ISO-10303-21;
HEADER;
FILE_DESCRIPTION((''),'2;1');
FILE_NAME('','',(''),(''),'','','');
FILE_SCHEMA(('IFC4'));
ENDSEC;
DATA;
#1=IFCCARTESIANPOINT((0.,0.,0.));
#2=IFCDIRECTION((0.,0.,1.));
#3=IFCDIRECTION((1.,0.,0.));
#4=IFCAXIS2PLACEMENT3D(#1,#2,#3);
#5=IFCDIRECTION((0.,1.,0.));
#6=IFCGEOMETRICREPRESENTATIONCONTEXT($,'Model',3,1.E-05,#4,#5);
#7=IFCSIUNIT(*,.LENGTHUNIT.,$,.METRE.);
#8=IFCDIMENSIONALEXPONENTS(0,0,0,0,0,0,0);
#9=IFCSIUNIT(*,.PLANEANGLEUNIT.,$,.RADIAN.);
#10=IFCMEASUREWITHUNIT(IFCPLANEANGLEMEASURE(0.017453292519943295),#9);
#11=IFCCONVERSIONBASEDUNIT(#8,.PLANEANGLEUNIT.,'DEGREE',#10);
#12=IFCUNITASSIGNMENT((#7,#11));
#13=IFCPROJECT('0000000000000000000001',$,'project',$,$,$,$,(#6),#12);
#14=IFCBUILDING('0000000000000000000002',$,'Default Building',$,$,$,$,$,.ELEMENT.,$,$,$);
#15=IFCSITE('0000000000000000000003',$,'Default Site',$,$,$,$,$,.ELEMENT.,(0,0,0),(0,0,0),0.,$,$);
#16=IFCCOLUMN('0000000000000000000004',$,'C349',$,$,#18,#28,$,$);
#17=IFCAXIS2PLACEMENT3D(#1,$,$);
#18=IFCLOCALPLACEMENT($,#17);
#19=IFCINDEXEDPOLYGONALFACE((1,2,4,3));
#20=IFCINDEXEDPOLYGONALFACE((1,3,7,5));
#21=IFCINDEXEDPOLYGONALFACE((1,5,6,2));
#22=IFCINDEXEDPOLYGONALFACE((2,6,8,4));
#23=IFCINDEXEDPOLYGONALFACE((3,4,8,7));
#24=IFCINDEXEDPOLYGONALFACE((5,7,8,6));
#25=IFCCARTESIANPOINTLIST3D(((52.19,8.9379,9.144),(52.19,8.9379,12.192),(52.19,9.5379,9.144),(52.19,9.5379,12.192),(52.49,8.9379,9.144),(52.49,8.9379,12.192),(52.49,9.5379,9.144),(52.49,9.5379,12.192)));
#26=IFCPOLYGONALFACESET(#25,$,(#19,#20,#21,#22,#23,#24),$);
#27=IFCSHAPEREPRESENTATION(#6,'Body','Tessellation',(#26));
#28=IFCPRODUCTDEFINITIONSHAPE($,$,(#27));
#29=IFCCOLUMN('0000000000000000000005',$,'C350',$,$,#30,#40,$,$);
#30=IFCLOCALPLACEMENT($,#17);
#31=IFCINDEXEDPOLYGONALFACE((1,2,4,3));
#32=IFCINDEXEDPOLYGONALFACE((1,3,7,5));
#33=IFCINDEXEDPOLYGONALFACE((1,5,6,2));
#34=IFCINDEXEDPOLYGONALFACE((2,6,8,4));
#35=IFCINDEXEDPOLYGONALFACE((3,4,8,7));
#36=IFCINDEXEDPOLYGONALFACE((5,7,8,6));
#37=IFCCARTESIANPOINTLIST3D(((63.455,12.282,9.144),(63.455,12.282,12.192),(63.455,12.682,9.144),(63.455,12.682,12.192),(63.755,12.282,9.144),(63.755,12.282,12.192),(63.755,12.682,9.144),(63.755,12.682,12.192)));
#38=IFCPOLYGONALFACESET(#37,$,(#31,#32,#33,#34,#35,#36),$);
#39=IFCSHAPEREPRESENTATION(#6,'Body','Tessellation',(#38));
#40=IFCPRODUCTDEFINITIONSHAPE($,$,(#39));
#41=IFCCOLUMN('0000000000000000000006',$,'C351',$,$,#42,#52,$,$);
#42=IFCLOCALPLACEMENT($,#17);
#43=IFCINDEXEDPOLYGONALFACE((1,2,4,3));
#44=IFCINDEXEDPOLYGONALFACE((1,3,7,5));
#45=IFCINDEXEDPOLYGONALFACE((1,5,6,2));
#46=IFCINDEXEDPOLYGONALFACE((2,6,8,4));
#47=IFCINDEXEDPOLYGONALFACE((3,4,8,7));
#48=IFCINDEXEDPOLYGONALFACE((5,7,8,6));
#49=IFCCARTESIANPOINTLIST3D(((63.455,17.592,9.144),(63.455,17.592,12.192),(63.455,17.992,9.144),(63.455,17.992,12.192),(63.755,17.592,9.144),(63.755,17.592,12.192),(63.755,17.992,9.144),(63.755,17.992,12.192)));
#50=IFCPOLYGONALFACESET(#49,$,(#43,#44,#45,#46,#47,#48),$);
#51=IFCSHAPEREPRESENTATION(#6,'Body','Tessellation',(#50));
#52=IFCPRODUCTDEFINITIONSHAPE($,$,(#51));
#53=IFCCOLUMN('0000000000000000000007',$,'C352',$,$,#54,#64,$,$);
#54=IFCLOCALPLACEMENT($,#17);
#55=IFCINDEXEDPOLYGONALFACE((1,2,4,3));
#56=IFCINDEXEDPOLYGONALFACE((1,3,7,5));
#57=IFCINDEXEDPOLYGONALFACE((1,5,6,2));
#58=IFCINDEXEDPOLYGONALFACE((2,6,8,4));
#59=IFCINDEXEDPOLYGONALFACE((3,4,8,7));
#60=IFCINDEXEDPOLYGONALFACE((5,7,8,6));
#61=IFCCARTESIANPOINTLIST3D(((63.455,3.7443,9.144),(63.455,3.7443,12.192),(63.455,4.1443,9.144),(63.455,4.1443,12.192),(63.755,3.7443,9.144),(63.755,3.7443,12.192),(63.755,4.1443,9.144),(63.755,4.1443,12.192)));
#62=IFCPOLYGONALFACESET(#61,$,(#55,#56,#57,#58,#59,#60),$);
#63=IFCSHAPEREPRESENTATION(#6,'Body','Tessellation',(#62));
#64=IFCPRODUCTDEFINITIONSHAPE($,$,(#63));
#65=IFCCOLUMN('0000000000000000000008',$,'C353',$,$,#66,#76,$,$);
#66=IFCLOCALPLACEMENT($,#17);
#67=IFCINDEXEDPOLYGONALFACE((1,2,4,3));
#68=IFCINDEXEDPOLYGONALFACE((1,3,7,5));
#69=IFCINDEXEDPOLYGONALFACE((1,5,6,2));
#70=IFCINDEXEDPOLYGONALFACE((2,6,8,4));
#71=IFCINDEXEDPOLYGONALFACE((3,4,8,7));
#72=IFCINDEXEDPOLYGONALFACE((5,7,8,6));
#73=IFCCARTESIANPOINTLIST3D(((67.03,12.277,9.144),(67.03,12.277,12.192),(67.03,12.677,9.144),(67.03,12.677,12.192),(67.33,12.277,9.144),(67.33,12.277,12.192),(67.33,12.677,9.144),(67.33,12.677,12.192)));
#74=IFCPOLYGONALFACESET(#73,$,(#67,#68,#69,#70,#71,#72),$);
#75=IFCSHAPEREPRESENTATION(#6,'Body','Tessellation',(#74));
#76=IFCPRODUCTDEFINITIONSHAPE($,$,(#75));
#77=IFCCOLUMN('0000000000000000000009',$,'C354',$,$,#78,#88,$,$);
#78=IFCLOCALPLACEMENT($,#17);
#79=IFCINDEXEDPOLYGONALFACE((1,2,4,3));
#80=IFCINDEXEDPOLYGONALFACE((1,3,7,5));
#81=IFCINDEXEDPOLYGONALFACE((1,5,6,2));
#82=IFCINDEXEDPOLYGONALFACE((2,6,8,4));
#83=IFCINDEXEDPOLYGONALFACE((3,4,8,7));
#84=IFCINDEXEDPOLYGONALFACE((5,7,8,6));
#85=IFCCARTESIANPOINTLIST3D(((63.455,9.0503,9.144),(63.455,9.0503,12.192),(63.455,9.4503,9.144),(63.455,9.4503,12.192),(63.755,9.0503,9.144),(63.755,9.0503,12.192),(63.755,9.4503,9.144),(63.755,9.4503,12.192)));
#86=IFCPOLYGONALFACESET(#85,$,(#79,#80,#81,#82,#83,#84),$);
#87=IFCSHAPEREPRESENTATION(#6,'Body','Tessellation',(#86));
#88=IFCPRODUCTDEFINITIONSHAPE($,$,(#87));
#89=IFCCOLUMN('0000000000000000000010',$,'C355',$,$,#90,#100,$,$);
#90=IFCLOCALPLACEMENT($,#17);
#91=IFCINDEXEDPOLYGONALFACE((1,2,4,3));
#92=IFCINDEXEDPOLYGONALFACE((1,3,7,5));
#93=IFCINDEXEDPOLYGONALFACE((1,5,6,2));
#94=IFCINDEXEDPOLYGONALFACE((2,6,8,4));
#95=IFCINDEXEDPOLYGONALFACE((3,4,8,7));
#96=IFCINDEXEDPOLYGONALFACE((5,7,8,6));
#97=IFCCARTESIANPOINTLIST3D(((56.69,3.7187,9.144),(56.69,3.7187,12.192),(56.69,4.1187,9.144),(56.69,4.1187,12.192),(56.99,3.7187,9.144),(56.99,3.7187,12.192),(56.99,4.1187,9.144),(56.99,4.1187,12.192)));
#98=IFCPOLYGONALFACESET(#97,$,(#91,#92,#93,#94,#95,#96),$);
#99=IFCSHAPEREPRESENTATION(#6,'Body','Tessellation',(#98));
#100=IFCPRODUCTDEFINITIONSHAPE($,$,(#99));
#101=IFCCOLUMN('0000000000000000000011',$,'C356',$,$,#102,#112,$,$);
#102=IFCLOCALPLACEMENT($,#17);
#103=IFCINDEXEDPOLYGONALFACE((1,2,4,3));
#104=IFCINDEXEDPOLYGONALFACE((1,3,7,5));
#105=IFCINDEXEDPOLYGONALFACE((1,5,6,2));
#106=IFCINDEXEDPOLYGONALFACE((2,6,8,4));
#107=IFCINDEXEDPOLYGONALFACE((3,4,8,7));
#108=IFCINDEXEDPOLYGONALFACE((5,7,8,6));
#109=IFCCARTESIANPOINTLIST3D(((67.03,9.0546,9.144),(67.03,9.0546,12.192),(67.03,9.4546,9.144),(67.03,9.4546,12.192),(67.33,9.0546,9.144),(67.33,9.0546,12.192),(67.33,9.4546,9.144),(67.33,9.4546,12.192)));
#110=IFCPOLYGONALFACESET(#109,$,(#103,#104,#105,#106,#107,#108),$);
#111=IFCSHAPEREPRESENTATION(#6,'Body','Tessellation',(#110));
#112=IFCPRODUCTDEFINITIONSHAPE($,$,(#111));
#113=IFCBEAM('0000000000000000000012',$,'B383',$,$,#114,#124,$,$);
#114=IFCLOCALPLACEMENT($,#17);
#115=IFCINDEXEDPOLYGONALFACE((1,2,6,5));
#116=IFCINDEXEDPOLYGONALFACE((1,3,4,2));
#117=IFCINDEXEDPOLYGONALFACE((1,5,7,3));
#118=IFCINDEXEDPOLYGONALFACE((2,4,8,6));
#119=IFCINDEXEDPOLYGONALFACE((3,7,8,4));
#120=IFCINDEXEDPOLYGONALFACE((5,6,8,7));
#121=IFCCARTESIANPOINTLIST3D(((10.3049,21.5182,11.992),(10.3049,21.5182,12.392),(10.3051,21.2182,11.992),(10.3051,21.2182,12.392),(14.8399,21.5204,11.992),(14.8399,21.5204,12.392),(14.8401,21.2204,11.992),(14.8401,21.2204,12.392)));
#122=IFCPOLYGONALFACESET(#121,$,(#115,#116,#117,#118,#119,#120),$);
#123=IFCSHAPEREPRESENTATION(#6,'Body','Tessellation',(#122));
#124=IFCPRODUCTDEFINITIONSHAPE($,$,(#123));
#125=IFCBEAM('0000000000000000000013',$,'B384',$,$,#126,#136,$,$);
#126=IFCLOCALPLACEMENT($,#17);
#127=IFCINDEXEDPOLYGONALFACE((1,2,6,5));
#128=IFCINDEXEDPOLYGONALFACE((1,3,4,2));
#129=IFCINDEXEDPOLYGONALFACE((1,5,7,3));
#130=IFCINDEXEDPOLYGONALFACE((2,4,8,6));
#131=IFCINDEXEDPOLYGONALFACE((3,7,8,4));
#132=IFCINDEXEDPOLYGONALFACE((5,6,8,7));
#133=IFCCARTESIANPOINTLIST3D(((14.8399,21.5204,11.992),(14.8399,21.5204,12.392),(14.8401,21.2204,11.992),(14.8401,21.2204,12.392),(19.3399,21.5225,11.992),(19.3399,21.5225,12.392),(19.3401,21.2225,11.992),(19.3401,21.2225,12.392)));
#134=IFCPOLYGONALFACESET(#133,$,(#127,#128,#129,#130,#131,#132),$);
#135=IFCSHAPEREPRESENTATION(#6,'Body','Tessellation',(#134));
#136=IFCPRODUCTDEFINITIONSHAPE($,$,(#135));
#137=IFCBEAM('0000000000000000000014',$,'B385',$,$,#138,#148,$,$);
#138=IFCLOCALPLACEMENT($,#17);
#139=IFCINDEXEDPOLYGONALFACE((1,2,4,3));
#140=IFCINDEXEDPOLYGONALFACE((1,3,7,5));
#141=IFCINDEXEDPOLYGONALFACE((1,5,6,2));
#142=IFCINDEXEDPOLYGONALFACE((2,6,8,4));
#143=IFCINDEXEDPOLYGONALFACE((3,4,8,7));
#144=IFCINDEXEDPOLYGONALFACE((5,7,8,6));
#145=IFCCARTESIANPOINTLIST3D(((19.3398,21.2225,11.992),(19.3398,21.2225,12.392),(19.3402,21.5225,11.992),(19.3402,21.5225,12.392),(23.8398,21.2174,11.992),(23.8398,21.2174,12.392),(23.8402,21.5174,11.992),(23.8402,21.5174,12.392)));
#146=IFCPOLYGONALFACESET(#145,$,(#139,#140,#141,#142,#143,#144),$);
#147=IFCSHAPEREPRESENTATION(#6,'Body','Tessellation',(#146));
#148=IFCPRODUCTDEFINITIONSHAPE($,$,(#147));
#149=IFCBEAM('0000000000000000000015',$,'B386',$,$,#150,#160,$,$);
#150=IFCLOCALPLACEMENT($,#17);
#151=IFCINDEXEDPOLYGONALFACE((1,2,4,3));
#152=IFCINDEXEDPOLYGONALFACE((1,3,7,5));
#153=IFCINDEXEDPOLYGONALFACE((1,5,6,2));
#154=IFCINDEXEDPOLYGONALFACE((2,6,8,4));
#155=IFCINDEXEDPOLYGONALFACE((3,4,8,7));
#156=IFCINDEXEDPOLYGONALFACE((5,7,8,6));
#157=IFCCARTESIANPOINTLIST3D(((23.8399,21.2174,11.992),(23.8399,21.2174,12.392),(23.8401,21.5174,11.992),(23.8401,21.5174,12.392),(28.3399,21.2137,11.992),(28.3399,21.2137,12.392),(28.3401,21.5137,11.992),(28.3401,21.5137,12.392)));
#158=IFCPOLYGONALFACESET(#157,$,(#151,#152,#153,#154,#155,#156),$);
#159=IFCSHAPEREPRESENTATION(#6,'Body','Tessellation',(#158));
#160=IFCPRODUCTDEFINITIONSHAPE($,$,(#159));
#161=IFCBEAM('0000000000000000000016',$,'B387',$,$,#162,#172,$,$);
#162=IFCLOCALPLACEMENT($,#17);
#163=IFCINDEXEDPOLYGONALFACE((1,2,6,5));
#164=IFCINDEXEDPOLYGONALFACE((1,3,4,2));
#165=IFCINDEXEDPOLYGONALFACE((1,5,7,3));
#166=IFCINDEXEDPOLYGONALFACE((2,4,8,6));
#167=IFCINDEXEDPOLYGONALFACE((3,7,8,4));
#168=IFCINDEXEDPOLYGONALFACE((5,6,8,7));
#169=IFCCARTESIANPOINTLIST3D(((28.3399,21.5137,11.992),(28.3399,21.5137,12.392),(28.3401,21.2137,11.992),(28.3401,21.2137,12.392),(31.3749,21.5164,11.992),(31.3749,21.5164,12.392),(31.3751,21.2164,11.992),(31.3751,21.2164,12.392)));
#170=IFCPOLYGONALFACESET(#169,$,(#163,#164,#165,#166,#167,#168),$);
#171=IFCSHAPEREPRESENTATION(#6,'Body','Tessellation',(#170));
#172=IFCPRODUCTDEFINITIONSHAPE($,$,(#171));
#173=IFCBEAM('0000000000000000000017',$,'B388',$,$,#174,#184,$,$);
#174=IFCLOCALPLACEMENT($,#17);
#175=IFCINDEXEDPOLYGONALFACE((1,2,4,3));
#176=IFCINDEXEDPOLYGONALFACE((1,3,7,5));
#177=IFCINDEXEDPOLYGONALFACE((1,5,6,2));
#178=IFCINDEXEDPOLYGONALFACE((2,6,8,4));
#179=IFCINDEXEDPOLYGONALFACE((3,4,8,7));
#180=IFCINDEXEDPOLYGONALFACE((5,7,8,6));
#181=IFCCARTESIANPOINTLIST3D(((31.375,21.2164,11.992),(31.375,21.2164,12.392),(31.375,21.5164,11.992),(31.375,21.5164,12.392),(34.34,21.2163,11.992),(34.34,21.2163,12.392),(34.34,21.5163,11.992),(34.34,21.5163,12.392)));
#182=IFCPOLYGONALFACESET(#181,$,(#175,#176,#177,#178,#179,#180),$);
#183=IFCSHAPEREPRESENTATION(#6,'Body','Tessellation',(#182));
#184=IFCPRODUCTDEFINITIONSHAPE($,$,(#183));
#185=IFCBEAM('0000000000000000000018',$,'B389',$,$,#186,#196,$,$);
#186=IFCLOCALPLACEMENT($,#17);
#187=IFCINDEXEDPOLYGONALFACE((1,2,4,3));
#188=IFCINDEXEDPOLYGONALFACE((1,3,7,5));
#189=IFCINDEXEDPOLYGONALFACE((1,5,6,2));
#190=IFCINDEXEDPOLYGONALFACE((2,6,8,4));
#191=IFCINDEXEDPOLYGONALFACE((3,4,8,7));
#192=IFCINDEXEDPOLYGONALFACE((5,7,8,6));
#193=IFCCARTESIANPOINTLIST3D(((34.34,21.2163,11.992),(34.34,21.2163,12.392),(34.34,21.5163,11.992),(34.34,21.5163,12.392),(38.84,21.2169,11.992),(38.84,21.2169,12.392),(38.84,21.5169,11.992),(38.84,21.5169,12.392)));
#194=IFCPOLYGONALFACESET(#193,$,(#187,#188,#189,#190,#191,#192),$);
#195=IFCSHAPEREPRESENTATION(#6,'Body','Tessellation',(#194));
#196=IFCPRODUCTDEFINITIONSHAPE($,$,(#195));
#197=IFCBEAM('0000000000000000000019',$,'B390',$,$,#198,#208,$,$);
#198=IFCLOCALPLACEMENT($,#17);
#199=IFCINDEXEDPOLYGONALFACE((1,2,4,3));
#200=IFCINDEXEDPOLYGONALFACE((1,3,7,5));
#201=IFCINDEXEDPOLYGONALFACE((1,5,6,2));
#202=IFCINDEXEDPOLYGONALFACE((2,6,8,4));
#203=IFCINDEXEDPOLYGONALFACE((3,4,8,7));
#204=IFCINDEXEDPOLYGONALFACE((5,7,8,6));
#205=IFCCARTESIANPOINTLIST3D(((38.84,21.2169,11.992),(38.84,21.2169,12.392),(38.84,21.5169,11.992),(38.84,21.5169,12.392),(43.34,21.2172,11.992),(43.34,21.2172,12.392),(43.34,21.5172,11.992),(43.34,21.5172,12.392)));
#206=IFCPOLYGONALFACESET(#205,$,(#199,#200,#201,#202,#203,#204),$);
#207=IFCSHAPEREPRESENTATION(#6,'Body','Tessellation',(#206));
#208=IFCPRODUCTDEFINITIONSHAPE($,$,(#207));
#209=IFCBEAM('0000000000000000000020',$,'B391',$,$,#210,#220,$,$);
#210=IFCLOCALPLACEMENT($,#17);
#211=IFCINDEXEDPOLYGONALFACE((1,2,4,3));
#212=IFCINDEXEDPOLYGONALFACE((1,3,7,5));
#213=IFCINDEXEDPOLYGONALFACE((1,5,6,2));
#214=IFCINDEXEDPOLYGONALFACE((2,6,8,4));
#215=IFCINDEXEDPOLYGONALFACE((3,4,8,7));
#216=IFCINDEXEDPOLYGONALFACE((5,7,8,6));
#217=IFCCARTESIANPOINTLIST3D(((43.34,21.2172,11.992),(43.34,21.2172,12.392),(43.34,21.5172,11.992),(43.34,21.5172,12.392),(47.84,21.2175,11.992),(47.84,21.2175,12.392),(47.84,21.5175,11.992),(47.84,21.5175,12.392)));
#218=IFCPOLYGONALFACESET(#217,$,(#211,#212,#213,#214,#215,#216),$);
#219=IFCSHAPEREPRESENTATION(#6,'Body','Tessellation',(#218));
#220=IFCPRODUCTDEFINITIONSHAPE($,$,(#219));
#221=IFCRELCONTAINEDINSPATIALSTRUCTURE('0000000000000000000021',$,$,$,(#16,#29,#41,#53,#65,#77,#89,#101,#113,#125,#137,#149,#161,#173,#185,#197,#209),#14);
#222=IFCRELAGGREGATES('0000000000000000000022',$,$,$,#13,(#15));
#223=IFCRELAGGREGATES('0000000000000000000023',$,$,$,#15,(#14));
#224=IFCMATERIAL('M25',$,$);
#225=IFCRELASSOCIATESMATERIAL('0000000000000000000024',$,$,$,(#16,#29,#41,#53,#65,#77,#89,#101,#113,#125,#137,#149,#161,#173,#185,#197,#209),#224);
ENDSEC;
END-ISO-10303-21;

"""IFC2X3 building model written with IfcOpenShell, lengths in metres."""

from ifc_helpers import new_model, entity, si_unit, converted_unit, direction, frame, frame_2d, origin_with_axes, place, context, project, spatial, rectangle, extrude, material, element, save


model = new_model("IFC2X3")

# Units and contexts
model_context = context("Model", 3, precision=1e-05, world=origin_with_axes(), true_north=direction((0.0, 1.0, 0.0)))
ifc_project = project(units=[si_unit("LENGTHUNIT", "METRE"), converted_unit("PLANEANGLEUNIT", "DEGREE", entity("IfcPlaneAngleMeasure", 0.017453292519943295), si_unit("PLANEANGLEUNIT", "RADIAN"), dimensions=[0, 0, 0, 0, 0, 0, 0])], contexts=[model_context])

# Site, building
site = spatial("IfcSite", under=ifc_project, Name="Default Site", CompositionType="ELEMENT", RefLatitude=(0, 0, 0), RefLongitude=(0, 0, 0), RefElevation=0.0)
building = spatial("IfcBuilding", under=site, Name="Default Building", CompositionType="ELEMENT")

# Columns
ifc_material = material(Name="M25")
placement = place(None, origin_with_axes())
element("IfcColumn", 1, at=placement, inside=building, material=ifc_material, Name="C349", context=model_context, shape_type="SweptSolid", body=[
    extrude(rectangle(XDim=0.3, YDim=0.6, at=frame_2d((0.0, 0.0), x_axis=(1.0, 0.0, 0.0))), frame((52.34, 9.2379, 9.144), z_axis=(0.0, 0.0, 1.0), x_axis=(1.0, 0.0, 0.0)), (0.0, 0.0, 1.0), 3.048),
])
element("IfcColumn", 2, at=placement, inside=building, material=ifc_material, Name="C350", context=model_context, shape_type="SweptSolid", body=[
    extrude(rectangle(XDim=0.3, YDim=0.4, at=frame_2d((0.0, 0.0), x_axis=(1.0, 0.0, 0.0))), frame((63.605, 12.482, 9.144), z_axis=(0.0, 0.0, 1.0), x_axis=(1.0, 0.0, 0.0)), (0.0, 0.0, 1.0), 3.048),
])
element("IfcColumn", 3, at=placement, inside=building, material=ifc_material, Name="C351", context=model_context, shape_type="SweptSolid", body=[
    extrude(rectangle(XDim=0.3, YDim=0.4, at=frame_2d((0.0, 0.0), x_axis=(1.0, 0.0, 0.0))), frame((63.605, 17.792, 9.144), z_axis=(0.0, 0.0, 1.0), x_axis=(1.0, 0.0, 0.0)), (0.0, 0.0, 1.0), 3.048),
])
element("IfcColumn", 4, at=placement, inside=building, material=ifc_material, Name="C352", context=model_context, shape_type="SweptSolid", body=[
    extrude(rectangle(XDim=0.3, YDim=0.4, at=frame_2d((0.0, 0.0), x_axis=(1.0, 0.0, 0.0))), frame((63.605, 3.9443, 9.144), z_axis=(0.0, 0.0, 1.0), x_axis=(1.0, 0.0, 0.0)), (0.0, 0.0, 1.0), 3.048),
])
element("IfcColumn", 5, at=placement, inside=building, material=ifc_material, Name="C353", context=model_context, shape_type="SweptSolid", body=[
    extrude(rectangle(XDim=0.3, YDim=0.4, at=frame_2d((0.0, 0.0), x_axis=(1.0, 0.0, 0.0))), frame((67.18, 12.477, 9.144), z_axis=(0.0, 0.0, 1.0), x_axis=(1.0, 0.0, 0.0)), (0.0, 0.0, 1.0), 3.048),
])
element("IfcColumn", 6, at=placement, inside=building, material=ifc_material, Name="C354", context=model_context, shape_type="SweptSolid", body=[
    extrude(rectangle(XDim=0.3, YDim=0.4, at=frame_2d((0.0, 0.0), x_axis=(1.0, 0.0, 0.0))), frame((63.605, 9.2503, 9.144), z_axis=(0.0, 0.0, 1.0), x_axis=(1.0, 0.0, 0.0)), (0.0, 0.0, 1.0), 3.048),
])
element("IfcColumn", 7, at=placement, inside=building, material=ifc_material, Name="C355", context=model_context, shape_type="SweptSolid", body=[
    extrude(rectangle(XDim=0.3, YDim=0.4, at=frame_2d((0.0, 0.0), x_axis=(1.0, 0.0, 0.0))), frame((56.84, 3.9187, 9.144), z_axis=(0.0, 0.0, 1.0), x_axis=(1.0, 0.0, 0.0)), (0.0, 0.0, 1.0), 3.048),
])
element("IfcColumn", 8, at=placement, inside=building, material=ifc_material, Name="C356", context=model_context, shape_type="SweptSolid", body=[
    extrude(rectangle(XDim=0.3, YDim=0.4, at=frame_2d((0.0, 0.0), x_axis=(1.0, 0.0, 0.0))), frame((67.18, 9.2546, 9.144), z_axis=(0.0, 0.0, 1.0), x_axis=(1.0, 0.0, 0.0)), (0.0, 0.0, 1.0), 3.048),
])

# Beams
element("IfcBeam", 9, at=placement, inside=building, material=ifc_material, Name="B383", context=model_context, shape_type="SweptSolid", body=[
    extrude(rectangle(XDim=0.3, YDim=0.4, at=frame_2d((0.0, 0.0), x_axis=(0.0, 1.0, 0.0))), frame((10.305, 21.3682, 12.192), z_axis=(1.0, 0.000476, 0.0), x_axis=(0.0, 0.0, -1.0)), (0.0, 0.0, 1.0), 4.535),
])
element("IfcBeam", 10, at=placement, inside=building, material=ifc_material, Name="B384", context=model_context, shape_type="SweptSolid", body=[
    extrude(rectangle(XDim=0.3, YDim=0.4, at=frame_2d((0.0, 0.0), x_axis=(0.0, 1.0, 0.0))), frame((14.84, 21.3704, 12.192), z_axis=(1.0, 0.000471, 0.0), x_axis=(0.0, 0.0, -1.0)), (0.0, 0.0, 1.0), 4.5),
])
element("IfcBeam", 11, at=placement, inside=building, material=ifc_material, Name="B385", context=model_context, shape_type="SweptSolid", body=[
    extrude(rectangle(XDim=0.3, YDim=0.4, at=frame_2d((0.0, 0.0), x_axis=(0.0, 1.0, 0.0))), frame((19.34, 21.3725, 12.192), z_axis=(0.999999, -0.001141, 0.0), x_axis=(0.0, 0.0, -1.0)), (0.0, 0.0, 1.0), 4.5),
])
element("IfcBeam", 12, at=placement, inside=building, material=ifc_material, Name="B386", context=model_context, shape_type="SweptSolid", body=[
    extrude(rectangle(XDim=0.3, YDim=0.4, at=frame_2d((0.0, 0.0), x_axis=(0.0, 1.0, 0.0))), frame((23.84, 21.3674, 12.192), z_axis=(1.0, -0.000812, 0.0), x_axis=(0.0, 0.0, -1.0)), (0.0, 0.0, 1.0), 4.5),
])
element("IfcBeam", 13, at=placement, inside=building, material=ifc_material, Name="B387", context=model_context, shape_type="SweptSolid", body=[
    extrude(rectangle(XDim=0.3, YDim=0.4, at=frame_2d((0.0, 0.0), x_axis=(0.0, 1.0, 0.0))), frame((28.34, 21.3637, 12.192), z_axis=(1.0, 0.000883, 0.0), x_axis=(0.0, 0.0, -1.0)), (0.0, 0.0, 1.0), 3.035),
])
element("IfcBeam", 14, at=placement, inside=building, material=ifc_material, Name="B388", context=model_context, shape_type="SweptSolid", body=[
    extrude(rectangle(XDim=0.3, YDim=0.4, at=frame_2d((0.0, 0.0), x_axis=(0.0, 1.0, 0.0))), frame((31.375, 21.3664, 12.192), z_axis=(1.0, -0.000016, 0.0), x_axis=(0.0, 0.0, -1.0)), (0.0, 0.0, 1.0), 2.965),
])
element("IfcBeam", 15, at=placement, inside=building, material=ifc_material, Name="B389", context=model_context, shape_type="SweptSolid", body=[
    extrude(rectangle(XDim=0.3, YDim=0.4, at=frame_2d((0.0, 0.0), x_axis=(0.0, 1.0, 0.0))), frame((34.34, 21.3663, 12.192), z_axis=(1.0, 0.000136, 0.0), x_axis=(0.0, 0.0, -1.0)), (0.0, 0.0, 1.0), 4.5),
])
element("IfcBeam", 16, at=placement, inside=building, material=ifc_material, Name="B390", context=model_context, shape_type="SweptSolid", body=[
    extrude(rectangle(XDim=0.3, YDim=0.4, at=frame_2d((0.0, 0.0), x_axis=(0.0, 1.0, 0.0))), frame((38.84, 21.3669, 12.192), z_axis=(1.0, 0.00005, 0.0), x_axis=(0.0, 0.0, -1.0)), (0.0, 0.0, 1.0), 4.5),
])
element("IfcBeam", 17, at=placement, inside=building, material=ifc_material, Name="B391", context=model_context, shape_type="SweptSolid", body=[
    extrude(rectangle(XDim=0.3, YDim=0.4, at=frame_2d((0.0, 0.0), x_axis=(0.0, 1.0, 0.0))), frame((43.34, 21.3672, 12.192), z_axis=(1.0, 0.000075, 0.0), x_axis=(0.0, 0.0, -1.0)), (0.0, 0.0, 1.0), 4.5),
])

save(model, "model.ifc")
